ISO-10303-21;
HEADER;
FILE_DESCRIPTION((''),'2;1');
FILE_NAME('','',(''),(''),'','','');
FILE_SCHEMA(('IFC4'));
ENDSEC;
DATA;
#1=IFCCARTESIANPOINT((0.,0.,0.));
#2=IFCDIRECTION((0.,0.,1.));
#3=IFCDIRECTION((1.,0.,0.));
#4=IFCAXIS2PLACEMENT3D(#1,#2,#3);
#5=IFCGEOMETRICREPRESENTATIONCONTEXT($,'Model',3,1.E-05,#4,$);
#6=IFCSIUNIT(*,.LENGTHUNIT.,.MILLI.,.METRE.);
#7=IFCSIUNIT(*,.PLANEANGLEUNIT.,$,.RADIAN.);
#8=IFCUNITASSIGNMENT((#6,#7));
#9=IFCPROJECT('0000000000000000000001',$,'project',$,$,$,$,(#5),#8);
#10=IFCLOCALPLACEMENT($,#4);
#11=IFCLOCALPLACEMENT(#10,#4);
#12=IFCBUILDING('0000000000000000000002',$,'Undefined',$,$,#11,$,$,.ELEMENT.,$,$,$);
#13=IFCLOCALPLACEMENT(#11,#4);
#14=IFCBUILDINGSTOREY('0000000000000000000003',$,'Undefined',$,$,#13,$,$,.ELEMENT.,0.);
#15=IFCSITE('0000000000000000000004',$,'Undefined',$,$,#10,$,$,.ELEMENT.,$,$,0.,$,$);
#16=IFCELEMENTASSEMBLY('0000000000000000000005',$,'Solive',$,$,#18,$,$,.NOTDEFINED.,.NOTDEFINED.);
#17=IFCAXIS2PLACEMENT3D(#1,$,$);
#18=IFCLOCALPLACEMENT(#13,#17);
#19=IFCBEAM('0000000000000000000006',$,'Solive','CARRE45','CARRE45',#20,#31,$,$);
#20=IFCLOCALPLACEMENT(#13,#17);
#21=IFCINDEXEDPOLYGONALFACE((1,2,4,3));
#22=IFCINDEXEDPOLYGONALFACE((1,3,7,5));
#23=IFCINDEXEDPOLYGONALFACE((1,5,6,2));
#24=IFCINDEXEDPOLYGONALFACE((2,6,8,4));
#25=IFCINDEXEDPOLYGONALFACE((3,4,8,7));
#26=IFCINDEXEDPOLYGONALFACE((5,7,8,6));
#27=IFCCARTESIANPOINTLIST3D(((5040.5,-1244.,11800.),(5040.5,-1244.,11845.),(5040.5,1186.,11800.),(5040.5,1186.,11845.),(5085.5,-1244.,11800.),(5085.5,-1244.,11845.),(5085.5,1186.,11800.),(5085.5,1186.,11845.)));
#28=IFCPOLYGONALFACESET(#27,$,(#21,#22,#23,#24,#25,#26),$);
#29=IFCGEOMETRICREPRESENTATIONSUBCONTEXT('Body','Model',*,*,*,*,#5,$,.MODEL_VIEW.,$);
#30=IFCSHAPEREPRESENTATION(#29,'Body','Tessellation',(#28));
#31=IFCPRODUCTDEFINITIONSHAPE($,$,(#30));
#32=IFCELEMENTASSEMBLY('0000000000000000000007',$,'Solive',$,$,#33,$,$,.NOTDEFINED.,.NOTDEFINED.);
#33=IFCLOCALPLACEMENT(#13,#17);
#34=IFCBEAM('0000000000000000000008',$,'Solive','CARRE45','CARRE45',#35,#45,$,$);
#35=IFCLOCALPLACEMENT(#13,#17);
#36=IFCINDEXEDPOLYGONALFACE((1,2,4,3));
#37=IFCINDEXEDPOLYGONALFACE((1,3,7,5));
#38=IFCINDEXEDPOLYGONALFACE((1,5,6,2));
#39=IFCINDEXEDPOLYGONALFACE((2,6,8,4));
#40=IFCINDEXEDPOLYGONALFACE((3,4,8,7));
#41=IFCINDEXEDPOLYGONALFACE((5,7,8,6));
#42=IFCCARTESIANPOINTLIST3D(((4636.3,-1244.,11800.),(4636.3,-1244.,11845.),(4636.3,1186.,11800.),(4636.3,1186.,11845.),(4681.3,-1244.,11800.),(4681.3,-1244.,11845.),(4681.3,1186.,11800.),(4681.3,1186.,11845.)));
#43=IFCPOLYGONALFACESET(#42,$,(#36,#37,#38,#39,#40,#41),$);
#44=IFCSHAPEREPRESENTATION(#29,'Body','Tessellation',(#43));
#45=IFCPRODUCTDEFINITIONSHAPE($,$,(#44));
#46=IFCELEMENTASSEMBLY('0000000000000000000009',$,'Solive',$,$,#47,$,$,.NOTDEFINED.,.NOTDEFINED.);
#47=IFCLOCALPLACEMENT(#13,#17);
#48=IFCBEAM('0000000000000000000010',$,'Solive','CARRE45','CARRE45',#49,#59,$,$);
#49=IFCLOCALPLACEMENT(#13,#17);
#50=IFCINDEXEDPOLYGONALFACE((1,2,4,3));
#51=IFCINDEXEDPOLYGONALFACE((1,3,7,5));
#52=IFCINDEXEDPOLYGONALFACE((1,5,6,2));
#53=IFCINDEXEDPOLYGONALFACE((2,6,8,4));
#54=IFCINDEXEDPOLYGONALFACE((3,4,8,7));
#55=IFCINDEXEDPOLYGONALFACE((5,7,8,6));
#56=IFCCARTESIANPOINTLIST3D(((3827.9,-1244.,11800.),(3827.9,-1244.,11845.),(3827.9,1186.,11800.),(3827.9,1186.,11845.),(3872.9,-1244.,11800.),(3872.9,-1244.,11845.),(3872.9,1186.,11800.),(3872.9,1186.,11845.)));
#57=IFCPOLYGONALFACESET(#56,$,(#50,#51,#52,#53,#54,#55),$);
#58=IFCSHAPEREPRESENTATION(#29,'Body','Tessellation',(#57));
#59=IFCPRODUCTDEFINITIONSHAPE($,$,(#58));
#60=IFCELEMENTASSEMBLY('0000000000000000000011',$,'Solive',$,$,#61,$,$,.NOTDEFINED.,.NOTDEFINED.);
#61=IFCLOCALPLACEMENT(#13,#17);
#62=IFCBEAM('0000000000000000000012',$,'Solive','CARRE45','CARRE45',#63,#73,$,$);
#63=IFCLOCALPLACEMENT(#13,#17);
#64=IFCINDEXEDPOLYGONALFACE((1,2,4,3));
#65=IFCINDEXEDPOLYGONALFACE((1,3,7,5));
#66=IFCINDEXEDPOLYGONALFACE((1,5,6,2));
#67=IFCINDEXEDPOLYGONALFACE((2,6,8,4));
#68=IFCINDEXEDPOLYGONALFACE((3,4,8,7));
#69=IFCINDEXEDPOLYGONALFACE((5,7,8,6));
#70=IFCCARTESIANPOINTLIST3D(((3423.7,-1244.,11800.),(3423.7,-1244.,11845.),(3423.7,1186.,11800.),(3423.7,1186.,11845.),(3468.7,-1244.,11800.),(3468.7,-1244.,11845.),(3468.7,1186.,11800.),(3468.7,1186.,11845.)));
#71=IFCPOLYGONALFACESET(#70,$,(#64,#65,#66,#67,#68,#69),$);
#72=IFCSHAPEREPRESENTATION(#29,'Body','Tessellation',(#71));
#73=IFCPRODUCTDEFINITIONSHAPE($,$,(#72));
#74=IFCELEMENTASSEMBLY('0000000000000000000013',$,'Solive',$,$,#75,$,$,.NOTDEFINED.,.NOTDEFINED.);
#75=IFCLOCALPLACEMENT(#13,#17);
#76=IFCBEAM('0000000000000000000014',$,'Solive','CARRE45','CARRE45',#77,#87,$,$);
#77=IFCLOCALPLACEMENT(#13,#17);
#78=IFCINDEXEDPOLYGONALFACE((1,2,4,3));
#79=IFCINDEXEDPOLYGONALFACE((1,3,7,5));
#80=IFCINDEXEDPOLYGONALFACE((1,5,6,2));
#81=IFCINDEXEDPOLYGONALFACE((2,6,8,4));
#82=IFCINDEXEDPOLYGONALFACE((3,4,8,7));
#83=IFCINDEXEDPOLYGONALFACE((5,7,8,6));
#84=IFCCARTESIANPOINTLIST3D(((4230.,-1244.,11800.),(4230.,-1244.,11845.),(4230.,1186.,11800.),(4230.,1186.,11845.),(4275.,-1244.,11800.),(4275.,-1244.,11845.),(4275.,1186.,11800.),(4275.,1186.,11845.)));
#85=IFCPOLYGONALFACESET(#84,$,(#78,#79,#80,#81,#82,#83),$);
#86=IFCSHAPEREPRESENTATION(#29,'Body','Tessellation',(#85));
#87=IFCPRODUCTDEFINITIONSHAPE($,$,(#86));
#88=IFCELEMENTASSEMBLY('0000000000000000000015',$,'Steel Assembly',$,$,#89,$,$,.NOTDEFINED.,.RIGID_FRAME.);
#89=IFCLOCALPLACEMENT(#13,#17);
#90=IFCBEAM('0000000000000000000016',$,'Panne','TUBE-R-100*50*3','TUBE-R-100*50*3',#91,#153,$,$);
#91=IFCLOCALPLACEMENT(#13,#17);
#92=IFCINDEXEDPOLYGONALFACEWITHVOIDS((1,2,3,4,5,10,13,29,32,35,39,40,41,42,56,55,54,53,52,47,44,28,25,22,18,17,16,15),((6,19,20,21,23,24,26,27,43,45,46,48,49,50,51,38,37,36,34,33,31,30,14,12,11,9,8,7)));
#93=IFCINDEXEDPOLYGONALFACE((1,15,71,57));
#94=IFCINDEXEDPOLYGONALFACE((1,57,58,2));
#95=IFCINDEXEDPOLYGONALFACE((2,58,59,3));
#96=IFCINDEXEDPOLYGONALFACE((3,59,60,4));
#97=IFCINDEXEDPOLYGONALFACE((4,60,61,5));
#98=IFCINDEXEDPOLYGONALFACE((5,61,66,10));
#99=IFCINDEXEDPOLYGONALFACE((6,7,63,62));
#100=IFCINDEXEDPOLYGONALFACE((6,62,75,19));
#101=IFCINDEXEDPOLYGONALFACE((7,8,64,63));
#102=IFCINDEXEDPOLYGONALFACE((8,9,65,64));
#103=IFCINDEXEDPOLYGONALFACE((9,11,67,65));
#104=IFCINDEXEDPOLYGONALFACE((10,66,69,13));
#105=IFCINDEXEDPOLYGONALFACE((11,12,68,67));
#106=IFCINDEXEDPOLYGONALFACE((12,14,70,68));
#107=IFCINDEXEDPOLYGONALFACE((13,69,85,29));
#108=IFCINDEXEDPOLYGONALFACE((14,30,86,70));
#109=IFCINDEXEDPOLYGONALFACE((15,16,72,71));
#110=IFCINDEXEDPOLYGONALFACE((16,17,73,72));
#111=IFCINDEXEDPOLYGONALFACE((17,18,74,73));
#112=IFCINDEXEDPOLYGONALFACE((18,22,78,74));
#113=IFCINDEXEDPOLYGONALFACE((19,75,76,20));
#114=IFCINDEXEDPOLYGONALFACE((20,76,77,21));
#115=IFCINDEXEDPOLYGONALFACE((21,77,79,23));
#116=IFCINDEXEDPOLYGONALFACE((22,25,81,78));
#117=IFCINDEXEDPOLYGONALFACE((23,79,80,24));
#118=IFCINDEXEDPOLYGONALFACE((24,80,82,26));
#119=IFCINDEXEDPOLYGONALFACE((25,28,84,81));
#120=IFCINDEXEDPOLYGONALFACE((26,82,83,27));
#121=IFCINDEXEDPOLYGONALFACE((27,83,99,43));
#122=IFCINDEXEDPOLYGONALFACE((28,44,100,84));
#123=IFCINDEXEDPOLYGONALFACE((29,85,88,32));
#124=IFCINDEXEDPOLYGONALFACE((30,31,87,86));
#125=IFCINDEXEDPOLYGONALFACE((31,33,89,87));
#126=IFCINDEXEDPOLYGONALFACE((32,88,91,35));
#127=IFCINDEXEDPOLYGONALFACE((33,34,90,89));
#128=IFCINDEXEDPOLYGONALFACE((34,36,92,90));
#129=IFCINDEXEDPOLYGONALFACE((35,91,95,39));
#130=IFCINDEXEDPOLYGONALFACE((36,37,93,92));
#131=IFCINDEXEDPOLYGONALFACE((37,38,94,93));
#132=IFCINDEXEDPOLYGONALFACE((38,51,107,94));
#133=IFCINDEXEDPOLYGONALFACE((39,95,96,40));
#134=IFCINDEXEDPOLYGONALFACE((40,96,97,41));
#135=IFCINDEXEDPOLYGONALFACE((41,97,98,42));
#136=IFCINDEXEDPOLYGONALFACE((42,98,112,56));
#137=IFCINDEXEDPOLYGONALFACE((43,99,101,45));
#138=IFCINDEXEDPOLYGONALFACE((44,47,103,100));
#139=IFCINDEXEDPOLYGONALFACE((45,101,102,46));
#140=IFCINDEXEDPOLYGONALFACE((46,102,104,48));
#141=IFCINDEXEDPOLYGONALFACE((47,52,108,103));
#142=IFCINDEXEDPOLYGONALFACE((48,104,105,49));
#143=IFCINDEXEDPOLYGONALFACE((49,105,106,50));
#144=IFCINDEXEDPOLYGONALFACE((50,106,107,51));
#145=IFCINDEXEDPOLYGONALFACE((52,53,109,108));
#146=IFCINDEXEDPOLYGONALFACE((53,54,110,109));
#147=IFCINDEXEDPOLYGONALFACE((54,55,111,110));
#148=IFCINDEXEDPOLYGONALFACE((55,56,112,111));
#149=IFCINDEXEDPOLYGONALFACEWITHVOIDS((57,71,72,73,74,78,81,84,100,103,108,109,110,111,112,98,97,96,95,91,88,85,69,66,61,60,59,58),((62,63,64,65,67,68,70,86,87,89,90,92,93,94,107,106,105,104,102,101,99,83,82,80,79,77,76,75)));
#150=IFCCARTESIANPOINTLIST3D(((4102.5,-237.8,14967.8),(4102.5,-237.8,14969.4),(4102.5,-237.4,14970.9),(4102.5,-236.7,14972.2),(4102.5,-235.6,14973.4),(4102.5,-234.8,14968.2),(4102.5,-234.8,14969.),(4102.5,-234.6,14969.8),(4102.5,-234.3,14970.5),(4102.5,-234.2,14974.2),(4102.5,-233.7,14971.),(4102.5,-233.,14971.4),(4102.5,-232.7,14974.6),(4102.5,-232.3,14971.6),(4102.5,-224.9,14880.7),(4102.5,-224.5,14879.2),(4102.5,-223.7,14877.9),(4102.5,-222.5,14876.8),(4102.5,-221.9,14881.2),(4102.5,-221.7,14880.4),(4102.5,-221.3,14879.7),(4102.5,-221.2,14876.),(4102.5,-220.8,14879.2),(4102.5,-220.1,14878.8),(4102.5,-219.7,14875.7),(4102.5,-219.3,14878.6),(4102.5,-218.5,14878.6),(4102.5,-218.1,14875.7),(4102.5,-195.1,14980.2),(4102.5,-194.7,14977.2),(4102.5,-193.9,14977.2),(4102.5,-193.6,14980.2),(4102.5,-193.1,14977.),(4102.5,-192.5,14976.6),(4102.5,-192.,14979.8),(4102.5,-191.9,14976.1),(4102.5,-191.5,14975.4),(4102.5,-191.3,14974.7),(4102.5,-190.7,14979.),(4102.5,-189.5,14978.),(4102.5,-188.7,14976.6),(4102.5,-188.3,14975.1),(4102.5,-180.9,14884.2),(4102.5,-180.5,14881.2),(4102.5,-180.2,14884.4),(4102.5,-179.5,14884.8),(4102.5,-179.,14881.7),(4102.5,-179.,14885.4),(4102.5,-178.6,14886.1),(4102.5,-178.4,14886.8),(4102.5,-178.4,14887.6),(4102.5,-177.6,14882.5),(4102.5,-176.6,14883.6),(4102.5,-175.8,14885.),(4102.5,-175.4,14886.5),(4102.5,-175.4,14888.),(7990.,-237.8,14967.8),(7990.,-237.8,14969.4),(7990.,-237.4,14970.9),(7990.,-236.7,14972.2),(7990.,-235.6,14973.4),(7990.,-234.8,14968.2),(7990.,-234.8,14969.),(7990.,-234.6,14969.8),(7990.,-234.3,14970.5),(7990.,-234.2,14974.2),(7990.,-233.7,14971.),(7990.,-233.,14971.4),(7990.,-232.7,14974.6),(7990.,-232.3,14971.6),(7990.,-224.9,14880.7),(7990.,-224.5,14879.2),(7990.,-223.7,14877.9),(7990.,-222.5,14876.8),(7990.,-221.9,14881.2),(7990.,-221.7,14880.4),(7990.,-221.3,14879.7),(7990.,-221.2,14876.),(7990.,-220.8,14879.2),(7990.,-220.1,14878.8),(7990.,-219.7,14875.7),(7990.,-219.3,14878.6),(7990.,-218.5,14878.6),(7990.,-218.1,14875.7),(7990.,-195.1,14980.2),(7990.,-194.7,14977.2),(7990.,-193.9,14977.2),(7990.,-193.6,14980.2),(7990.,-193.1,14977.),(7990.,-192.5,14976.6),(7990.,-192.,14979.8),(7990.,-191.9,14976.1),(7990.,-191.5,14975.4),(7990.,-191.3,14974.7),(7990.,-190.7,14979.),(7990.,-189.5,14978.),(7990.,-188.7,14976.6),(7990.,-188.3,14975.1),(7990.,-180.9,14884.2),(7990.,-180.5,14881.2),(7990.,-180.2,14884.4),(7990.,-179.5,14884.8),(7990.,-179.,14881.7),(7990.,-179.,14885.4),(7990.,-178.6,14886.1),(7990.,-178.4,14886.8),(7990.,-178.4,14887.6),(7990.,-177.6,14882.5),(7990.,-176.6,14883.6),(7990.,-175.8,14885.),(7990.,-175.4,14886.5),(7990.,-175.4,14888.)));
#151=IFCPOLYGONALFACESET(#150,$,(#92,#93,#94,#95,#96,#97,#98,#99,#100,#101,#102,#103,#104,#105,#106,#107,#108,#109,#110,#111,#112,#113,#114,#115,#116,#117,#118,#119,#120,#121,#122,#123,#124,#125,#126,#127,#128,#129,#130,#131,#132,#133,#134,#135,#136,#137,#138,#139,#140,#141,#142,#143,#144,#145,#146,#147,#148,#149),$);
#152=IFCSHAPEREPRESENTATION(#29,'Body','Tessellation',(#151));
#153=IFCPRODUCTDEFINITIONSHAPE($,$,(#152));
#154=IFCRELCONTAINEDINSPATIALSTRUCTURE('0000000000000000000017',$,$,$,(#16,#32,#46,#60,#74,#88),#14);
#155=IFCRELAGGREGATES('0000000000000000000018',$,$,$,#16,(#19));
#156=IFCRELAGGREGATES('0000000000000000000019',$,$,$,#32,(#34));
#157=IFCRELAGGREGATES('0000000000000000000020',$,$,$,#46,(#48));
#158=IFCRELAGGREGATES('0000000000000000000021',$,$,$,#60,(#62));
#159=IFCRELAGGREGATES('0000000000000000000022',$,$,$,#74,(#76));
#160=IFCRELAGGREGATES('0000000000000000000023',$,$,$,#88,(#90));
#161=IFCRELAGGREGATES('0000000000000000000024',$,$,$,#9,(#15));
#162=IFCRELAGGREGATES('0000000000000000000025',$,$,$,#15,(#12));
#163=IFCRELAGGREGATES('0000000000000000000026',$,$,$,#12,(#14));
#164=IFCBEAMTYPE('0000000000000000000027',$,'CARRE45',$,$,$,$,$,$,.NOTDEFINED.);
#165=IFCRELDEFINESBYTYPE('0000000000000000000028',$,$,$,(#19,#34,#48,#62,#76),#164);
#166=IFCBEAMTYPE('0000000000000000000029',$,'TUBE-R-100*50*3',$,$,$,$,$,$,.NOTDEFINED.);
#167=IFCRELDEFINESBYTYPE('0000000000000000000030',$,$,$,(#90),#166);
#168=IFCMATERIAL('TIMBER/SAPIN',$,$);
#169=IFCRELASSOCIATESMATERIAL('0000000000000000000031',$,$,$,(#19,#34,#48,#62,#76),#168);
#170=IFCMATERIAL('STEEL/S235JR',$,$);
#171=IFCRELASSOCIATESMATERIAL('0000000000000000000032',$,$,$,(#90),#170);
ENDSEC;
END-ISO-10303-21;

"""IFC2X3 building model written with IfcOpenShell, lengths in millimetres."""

from ifc_helpers import new_model, si_unit, frame, origin_with_axes, origin_2d_with_axis, place, context, subcontext, project, spatial, rectangle, hollow_rectangle, extrude, material, type_object, element, aggregate, save


model = new_model("IFC2X3")

# Units and contexts
model_context = context("Model", 3, precision=1e-05, world=origin_with_axes())
body_context = subcontext(model_context, "Body", "Model", "MODEL_VIEW")
ifc_project = project(units=[si_unit("LENGTHUNIT", "METRE", prefix="MILLI"), si_unit("PLANEANGLEUNIT", "RADIAN")], contexts=[model_context])

# Site, building, storey
site_placement = place(None, origin_with_axes())
site = spatial("IfcSite", under=ifc_project, at=site_placement, Name="Undefined", CompositionType="ELEMENT", RefElevation=0.0)
building_placement = place(site_placement, origin_with_axes())
building = spatial("IfcBuilding", under=site, at=building_placement, Name="Undefined", CompositionType="ELEMENT")
storey_placement = place(building_placement, origin_with_axes())
storey = spatial("IfcBuildingStorey", under=building, at=storey_placement, Name="Undefined", CompositionType="ELEMENT", Elevation=0.0)

# Element assemblies, beams
assembly_1_placement = place(storey_placement, origin_with_axes())
assembly_1 = element("IfcElementAssembly", 1, at=assembly_1_placement, inside=storey, Name="Solive", AssemblyPlace="NOTDEFINED", PredefinedType="NOTDEFINED")
ifc_material_1 = material(Name="TIMBER/SAPIN")
beam_type_1 = type_object("IfcBeamType", Name="CARRE45", PredefinedType="NOTDEFINED")
beam_1_placement = place(assembly_1_placement, frame((5063.0, 1186.0, 11822.5), z_axis=(0.0, 0.0, -1.0), x_axis=(0.0, -1.0, 0.0)))
beam_1 = element("IfcBeam", 2, at=beam_1_placement, type_object=beam_type_1, material=ifc_material_1, Name="Solive", Description="CARRE45", ObjectType="CARRE45", context=body_context, shape_type="SweptSolid", body=[
    extrude(rectangle(XDim=45.0, YDim=45.0, at=origin_2d_with_axis()), frame((2430.0, 0.0, 0.0), z_axis=(-1.0, 0.0, 0.0), x_axis=(0.0, -1.0, 0.0)), (0.0, 0.0, 1.0), 2430.0),
])
aggregate(assembly_1, [beam_1])
assembly_2_placement = place(storey_placement, origin_with_axes())
assembly_2 = element("IfcElementAssembly", 3, at=assembly_2_placement, inside=storey, Name="Solive", AssemblyPlace="NOTDEFINED", PredefinedType="NOTDEFINED")
beam_2_placement = place(assembly_2_placement, frame((4658.8, 1186.0, 11822.5), z_axis=(0.0, 0.0, -1.0), x_axis=(0.0, -1.0, 0.0)))
beam_2 = element("IfcBeam", 4, at=beam_2_placement, type_object=beam_type_1, material=ifc_material_1, Name="Solive", Description="CARRE45", ObjectType="CARRE45", context=body_context, shape_type="SweptSolid", body=[
    extrude(rectangle(XDim=45.0, YDim=45.0, at=origin_2d_with_axis()), frame((2430.0, 0.0, 0.0), z_axis=(-1.0, 0.0, 0.0), x_axis=(0.0, -1.0, 0.0)), (0.0, 0.0, 1.0), 2430.0),
])
aggregate(assembly_2, [beam_2])
assembly_3_placement = place(storey_placement, origin_with_axes())
assembly_3 = element("IfcElementAssembly", 5, at=assembly_3_placement, inside=storey, Name="Solive", AssemblyPlace="NOTDEFINED", PredefinedType="NOTDEFINED")
beam_3_placement = place(assembly_3_placement, frame((3850.4, 1186.0, 11822.5), z_axis=(0.0, 0.0, -1.0), x_axis=(0.0, -1.0, 0.0)))
beam_3 = element("IfcBeam", 6, at=beam_3_placement, type_object=beam_type_1, material=ifc_material_1, Name="Solive", Description="CARRE45", ObjectType="CARRE45", context=body_context, shape_type="SweptSolid", body=[
    extrude(rectangle(XDim=45.0, YDim=45.0, at=origin_2d_with_axis()), frame((2430.0, 0.0, 0.0), z_axis=(-1.0, 0.0, 0.0), x_axis=(0.0, -1.0, 0.0)), (0.0, 0.0, 1.0), 2430.0),
])
aggregate(assembly_3, [beam_3])
assembly_4_placement = place(storey_placement, origin_with_axes())
assembly_4 = element("IfcElementAssembly", 7, at=assembly_4_placement, inside=storey, Name="Solive", AssemblyPlace="NOTDEFINED", PredefinedType="NOTDEFINED")
beam_4_placement = place(assembly_4_placement, frame((3446.2, 1186.0, 11822.5), z_axis=(0.0, 0.0, -1.0), x_axis=(0.0, -1.0, 0.0)))
beam_4 = element("IfcBeam", 8, at=beam_4_placement, type_object=beam_type_1, material=ifc_material_1, Name="Solive", Description="CARRE45", ObjectType="CARRE45", context=body_context, shape_type="SweptSolid", body=[
    extrude(rectangle(XDim=45.0, YDim=45.0, at=origin_2d_with_axis()), frame((2430.0, 0.0, 0.0), z_axis=(-1.0, 0.0, 0.0), x_axis=(0.0, -1.0, 0.0)), (0.0, 0.0, 1.0), 2430.0),
])
aggregate(assembly_4, [beam_4])
assembly_5_placement = place(storey_placement, origin_with_axes())
assembly_5 = element("IfcElementAssembly", 9, at=assembly_5_placement, inside=storey, Name="Solive", AssemblyPlace="NOTDEFINED", PredefinedType="NOTDEFINED")
beam_5_placement = place(assembly_5_placement, frame((4252.5, 1186.0, 11822.5), z_axis=(0.0, 0.0, -1.0), x_axis=(0.0, -1.0, 0.0)))
beam_5 = element("IfcBeam", 10, at=beam_5_placement, type_object=beam_type_1, material=ifc_material_1, Name="Solive", Description="CARRE45", ObjectType="CARRE45", context=body_context, shape_type="SweptSolid", body=[
    extrude(rectangle(XDim=45.0, YDim=45.0, at=origin_2d_with_axis()), frame((2430.0, 0.0, 0.0), z_axis=(-1.0, 0.0, 0.0), x_axis=(0.0, -1.0, 0.0)), (0.0, 0.0, 1.0), 2430.0),
])
aggregate(assembly_5, [beam_5])
assembly_6_placement = place(storey_placement, origin_with_axes())
assembly_6 = element("IfcElementAssembly", 11, at=assembly_6_placement, inside=storey, Name="Steel Assembly", AssemblyPlace="NOTDEFINED", PredefinedType="RIGID_FRAME")
ifc_material_2 = material(Name="STEEL/S235JR")
beam_type_2 = type_object("IfcBeamType", Name="TUBE-R-100*50*3", PredefinedType="NOTDEFINED")
beam_6_placement = place(assembly_6_placement, frame((4102.5, -206.6, 14927.9), z_axis=(0.0, 0.146286, -0.989242), x_axis=(1.0, 0.0, 0.0)))
beam_6 = element("IfcBeam", 12, at=beam_6_placement, type_object=beam_type_2, material=ifc_material_2, Name="Panne", Description="TUBE-R-100*50*3", ObjectType="TUBE-R-100*50*3", context=body_context, shape_type="SweptSolid", body=[
    extrude(hollow_rectangle(XDim=50.0, YDim=100.0, WallThickness=3.0, InnerFilletRadius=3.0, OuterFilletRadius=6.0, at=origin_2d_with_axis()), frame((3887.5, 0.0, 0.0), z_axis=(-1.0, 0.0, 0.0), x_axis=(0.0, -1.0, 0.0)), (0.0, 0.0, 1.0), 3887.5),
])
aggregate(assembly_6, [beam_6])

save(model, "model.ifc")
